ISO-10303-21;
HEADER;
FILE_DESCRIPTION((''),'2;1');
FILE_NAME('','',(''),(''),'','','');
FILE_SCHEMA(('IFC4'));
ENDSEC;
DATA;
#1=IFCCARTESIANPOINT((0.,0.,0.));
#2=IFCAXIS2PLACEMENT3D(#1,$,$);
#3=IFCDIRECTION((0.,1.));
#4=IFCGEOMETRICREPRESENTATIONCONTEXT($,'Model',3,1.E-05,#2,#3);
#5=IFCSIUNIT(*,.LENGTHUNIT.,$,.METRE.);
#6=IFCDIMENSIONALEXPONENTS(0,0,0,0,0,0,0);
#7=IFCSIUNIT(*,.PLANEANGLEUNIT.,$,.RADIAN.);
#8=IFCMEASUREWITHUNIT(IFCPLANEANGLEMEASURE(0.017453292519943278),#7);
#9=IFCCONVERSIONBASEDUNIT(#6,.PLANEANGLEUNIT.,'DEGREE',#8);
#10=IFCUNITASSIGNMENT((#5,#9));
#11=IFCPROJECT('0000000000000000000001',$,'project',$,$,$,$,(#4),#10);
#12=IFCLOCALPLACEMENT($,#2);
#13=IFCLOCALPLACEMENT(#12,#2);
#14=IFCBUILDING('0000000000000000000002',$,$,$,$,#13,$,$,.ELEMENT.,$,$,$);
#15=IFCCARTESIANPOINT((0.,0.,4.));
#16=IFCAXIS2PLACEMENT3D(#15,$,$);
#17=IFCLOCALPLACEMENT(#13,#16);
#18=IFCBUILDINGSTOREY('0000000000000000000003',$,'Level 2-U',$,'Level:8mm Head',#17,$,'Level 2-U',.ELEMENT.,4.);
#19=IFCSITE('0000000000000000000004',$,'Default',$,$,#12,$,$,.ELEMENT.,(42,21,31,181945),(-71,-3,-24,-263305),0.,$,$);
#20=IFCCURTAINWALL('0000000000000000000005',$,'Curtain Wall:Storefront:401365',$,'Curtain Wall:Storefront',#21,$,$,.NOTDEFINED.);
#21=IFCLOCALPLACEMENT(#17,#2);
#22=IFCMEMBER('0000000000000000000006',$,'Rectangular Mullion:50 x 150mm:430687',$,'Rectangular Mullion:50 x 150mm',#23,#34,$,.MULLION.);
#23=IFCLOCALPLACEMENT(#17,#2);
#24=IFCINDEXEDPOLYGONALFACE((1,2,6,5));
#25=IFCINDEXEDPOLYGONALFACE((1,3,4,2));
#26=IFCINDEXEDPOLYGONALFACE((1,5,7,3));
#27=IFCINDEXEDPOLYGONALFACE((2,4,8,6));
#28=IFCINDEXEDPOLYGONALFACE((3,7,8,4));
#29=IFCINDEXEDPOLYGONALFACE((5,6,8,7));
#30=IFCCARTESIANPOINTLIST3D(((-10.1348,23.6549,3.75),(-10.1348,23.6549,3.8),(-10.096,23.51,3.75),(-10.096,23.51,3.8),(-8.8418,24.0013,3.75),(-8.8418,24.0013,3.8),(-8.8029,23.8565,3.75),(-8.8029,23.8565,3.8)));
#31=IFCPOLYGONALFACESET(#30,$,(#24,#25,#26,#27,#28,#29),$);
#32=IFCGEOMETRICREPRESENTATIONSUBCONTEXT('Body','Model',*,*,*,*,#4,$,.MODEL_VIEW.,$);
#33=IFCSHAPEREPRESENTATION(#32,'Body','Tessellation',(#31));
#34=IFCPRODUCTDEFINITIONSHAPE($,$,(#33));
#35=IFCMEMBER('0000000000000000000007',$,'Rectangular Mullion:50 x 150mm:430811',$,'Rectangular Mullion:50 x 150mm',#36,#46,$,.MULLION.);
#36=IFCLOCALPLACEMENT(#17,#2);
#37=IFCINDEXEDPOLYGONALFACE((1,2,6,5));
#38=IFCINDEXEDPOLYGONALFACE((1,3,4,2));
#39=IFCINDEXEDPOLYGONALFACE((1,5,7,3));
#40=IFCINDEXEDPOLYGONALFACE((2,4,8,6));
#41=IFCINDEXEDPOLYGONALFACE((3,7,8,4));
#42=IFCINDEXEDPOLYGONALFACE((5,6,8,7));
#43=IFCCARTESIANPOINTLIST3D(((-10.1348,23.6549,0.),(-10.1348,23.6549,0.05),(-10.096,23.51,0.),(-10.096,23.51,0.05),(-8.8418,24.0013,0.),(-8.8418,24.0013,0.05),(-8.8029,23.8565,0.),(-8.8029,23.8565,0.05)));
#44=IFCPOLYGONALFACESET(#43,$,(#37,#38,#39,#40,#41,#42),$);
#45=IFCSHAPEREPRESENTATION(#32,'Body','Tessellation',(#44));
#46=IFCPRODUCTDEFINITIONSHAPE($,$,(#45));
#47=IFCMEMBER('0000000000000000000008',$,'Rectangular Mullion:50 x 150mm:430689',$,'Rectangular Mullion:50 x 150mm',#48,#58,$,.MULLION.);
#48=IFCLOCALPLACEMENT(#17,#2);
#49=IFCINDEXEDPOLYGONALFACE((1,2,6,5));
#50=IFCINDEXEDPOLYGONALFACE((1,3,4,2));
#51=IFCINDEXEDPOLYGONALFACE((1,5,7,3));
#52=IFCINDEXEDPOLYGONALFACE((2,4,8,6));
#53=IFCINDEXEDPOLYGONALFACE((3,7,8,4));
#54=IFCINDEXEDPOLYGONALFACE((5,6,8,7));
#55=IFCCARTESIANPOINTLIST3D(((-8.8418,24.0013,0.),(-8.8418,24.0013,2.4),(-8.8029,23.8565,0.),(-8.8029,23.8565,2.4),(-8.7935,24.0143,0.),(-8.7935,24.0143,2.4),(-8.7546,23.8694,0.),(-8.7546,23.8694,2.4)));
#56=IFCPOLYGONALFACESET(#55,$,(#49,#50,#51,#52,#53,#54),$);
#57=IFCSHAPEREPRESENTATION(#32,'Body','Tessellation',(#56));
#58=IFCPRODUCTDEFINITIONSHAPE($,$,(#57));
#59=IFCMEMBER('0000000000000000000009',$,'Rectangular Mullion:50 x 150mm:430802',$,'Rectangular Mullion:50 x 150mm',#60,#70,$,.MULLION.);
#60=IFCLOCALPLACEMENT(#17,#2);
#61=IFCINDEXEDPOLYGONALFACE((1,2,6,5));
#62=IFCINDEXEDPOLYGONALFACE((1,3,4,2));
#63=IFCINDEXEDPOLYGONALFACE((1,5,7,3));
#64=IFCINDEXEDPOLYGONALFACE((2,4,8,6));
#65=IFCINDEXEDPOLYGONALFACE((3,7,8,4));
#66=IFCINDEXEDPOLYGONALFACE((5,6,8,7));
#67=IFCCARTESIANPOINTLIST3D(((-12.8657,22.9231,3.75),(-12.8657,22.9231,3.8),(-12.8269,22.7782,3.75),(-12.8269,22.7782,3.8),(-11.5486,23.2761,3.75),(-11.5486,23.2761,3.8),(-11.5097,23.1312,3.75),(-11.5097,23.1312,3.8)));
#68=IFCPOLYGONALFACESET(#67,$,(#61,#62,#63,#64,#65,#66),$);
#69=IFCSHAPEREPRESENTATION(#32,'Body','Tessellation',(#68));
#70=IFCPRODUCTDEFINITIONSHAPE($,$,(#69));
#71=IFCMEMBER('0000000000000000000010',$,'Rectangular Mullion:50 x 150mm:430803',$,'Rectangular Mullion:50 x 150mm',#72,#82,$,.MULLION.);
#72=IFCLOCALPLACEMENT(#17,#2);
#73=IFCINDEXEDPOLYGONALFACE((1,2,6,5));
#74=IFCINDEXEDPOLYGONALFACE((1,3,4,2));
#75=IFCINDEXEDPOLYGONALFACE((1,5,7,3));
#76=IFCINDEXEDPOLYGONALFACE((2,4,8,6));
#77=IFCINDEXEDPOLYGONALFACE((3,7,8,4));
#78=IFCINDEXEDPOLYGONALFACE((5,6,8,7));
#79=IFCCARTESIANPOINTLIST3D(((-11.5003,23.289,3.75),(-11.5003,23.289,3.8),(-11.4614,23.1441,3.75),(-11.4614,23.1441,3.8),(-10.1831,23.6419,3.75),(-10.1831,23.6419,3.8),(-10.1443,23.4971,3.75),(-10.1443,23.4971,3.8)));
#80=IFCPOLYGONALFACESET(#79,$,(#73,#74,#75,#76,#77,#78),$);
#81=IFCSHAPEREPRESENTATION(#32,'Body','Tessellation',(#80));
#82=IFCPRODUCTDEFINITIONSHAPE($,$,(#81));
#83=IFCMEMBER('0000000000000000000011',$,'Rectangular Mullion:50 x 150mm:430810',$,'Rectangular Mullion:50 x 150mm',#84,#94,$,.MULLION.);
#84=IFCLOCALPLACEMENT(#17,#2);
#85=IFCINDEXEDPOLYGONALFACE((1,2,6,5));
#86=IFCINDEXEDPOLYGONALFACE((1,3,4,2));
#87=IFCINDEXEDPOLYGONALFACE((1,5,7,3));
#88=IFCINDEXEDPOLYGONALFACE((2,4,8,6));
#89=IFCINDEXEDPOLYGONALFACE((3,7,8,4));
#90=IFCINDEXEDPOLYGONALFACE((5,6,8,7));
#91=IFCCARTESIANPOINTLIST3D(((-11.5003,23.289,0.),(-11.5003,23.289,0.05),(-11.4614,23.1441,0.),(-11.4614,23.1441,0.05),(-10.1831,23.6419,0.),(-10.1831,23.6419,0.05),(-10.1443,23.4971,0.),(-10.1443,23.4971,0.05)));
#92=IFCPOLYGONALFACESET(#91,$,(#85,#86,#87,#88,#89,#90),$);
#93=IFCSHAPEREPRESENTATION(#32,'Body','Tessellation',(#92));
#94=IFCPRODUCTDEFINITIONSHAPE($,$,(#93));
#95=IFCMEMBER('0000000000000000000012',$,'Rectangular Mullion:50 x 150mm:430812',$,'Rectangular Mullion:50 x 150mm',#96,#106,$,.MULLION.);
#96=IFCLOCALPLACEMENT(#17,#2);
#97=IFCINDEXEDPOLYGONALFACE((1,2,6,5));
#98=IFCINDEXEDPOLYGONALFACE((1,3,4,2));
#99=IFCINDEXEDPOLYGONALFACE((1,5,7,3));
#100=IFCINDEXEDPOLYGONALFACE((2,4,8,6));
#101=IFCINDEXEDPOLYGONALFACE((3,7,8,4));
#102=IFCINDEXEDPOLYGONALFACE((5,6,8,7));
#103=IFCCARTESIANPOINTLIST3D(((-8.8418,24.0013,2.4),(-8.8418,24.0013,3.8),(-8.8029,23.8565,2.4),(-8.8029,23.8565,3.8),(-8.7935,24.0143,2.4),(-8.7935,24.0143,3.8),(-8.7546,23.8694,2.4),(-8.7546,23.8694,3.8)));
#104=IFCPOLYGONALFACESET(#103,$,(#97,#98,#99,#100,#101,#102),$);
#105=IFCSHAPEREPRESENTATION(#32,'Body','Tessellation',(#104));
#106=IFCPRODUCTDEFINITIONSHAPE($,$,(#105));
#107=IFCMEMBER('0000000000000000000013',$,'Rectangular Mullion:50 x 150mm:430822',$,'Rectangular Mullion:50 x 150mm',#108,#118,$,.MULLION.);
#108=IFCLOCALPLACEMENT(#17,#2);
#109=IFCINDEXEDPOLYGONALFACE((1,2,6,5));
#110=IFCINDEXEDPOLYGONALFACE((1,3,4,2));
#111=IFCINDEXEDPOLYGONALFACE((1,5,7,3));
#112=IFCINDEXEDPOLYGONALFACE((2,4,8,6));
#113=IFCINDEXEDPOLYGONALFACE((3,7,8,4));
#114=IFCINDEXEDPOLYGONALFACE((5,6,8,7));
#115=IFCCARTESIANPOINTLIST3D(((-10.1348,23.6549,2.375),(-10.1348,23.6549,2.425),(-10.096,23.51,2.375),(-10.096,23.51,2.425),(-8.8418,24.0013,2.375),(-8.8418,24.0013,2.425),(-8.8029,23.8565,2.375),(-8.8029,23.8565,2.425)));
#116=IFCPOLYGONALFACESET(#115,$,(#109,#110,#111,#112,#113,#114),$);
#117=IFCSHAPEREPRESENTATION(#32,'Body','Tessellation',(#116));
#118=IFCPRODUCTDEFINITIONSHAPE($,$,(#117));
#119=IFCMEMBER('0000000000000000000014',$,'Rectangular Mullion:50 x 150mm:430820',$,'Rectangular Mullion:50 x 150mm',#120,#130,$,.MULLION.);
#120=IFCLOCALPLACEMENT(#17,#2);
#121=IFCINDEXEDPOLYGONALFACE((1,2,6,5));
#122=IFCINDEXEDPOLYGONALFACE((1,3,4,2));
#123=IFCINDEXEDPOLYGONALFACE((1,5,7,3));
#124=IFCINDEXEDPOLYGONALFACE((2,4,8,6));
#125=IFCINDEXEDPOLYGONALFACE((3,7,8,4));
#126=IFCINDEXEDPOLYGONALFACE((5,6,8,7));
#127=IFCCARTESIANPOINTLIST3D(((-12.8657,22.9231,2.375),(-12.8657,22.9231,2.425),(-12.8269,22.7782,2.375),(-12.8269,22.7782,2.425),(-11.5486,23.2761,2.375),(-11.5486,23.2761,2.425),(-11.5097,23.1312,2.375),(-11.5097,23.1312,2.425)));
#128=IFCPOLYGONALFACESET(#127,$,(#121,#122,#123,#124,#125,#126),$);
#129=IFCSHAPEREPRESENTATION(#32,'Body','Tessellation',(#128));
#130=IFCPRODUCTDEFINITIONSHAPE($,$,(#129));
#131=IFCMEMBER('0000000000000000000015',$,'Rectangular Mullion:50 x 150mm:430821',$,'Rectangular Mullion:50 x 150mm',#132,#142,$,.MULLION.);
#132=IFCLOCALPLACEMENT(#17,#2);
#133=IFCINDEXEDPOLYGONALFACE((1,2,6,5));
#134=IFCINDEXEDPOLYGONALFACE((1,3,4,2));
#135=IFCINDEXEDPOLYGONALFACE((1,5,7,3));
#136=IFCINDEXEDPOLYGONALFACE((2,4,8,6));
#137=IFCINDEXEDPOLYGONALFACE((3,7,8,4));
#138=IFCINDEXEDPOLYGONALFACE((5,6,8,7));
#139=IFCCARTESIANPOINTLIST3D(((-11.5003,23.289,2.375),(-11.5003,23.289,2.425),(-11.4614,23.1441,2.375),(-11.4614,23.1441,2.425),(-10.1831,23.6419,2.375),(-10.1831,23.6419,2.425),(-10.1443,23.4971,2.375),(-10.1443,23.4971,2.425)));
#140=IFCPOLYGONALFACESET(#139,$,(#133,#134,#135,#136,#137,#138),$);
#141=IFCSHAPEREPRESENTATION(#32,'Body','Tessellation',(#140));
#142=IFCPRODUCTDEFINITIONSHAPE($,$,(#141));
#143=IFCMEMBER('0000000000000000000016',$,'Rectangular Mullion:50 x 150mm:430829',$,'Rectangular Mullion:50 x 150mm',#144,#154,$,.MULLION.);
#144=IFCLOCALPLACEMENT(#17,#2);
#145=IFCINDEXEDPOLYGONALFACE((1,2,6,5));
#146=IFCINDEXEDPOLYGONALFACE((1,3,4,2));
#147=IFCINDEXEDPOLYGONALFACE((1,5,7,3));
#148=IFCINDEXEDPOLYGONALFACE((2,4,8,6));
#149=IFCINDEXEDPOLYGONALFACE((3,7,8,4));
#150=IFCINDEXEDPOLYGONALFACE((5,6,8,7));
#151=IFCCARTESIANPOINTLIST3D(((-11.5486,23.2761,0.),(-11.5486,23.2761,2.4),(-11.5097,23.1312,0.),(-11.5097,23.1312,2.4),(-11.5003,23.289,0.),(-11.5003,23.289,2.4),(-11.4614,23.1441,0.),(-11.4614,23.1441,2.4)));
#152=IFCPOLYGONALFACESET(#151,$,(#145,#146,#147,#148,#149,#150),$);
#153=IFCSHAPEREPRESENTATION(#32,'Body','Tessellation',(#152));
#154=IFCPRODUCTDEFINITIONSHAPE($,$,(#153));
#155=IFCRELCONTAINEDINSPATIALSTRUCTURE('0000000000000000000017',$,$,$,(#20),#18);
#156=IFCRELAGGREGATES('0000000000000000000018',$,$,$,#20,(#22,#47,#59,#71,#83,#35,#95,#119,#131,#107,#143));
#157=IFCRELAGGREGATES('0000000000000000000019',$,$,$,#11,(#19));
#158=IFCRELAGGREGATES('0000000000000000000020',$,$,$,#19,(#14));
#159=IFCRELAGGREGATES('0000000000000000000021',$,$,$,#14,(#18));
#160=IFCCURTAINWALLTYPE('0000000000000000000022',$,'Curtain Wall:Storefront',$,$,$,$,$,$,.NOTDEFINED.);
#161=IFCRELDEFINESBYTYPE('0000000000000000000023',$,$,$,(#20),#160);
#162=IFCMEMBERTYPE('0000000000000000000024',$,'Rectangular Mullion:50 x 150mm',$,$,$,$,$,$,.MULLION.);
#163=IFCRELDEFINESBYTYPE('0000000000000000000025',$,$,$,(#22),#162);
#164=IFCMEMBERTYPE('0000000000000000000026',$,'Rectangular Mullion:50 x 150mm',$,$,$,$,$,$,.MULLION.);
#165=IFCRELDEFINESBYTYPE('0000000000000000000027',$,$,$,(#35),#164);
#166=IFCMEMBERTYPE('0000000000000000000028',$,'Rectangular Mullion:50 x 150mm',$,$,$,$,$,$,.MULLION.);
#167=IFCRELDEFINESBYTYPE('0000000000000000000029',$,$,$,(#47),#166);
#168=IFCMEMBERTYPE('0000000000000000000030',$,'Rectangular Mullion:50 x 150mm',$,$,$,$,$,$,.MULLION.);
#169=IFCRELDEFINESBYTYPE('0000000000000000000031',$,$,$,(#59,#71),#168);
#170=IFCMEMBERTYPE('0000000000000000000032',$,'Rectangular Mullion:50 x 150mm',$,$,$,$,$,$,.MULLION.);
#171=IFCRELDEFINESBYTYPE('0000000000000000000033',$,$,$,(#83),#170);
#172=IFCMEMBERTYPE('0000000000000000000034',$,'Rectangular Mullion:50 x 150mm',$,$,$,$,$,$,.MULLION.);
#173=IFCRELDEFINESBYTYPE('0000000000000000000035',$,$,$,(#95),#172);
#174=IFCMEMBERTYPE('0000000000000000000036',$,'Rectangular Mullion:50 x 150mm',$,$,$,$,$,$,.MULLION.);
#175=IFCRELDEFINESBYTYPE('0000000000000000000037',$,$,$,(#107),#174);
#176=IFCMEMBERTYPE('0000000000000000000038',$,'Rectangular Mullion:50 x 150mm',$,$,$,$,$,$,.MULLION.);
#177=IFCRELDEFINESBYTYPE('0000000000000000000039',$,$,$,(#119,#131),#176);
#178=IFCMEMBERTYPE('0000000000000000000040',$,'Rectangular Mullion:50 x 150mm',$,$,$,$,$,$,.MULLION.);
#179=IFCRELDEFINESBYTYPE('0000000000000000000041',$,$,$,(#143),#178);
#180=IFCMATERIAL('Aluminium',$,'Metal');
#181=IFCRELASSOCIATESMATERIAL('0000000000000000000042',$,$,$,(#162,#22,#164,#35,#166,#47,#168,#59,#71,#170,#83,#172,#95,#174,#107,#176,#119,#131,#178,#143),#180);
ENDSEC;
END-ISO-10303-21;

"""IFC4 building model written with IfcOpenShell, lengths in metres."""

from ifc_helpers import new_model, entity, si_unit, converted_unit, direction, frame, origin, place, context, subcontext, project, spatial, indexed_curve, outline, extrude, source, transform, mapped, material, type_object, type_shapes, element, aggregate, save


model = new_model("IFC4")

# Units and contexts
model_context = context("Model", 3, precision=1e-05, world=origin(), true_north=direction((0.0, 1.0)))
body_context = subcontext(model_context, "Body", "Model", "MODEL_VIEW")
ifc_project = project(units=[si_unit("LENGTHUNIT", "METRE"), converted_unit("PLANEANGLEUNIT", "DEGREE", entity("IfcPlaneAngleMeasure", 0.017453292519943278), si_unit("PLANEANGLEUNIT", "RADIAN"), dimensions=[0, 0, 0, 0, 0, 0, 0])], contexts=[model_context])

# Site, building, storey
site_placement = place(None, origin())
site = spatial("IfcSite", under=ifc_project, at=site_placement, Name="Default", CompositionType="ELEMENT", RefLatitude=(42, 21, 31, 181945), RefLongitude=(-71, -3, -24, -263305), RefElevation=0.0)
building_placement = place(site_placement, origin())
building = spatial("IfcBuilding", under=site, at=building_placement, CompositionType="ELEMENT")
storey_placement = place(building_placement, frame((0.0, 0.0, 4.0)))
storey = spatial("IfcBuildingStorey", under=building, at=storey_placement, Name="Level 2-U", ObjectType="Level:8mm Head", LongName="Level 2-U", CompositionType="ELEMENT", Elevation=4.0)

# Curtain wall, members
curtain_wall_type = type_object("IfcCurtainWallType", Name="Curtain Wall:Storefront", PredefinedType="NOTDEFINED")
curtain_wall_placement = place(storey_placement, frame((0.0, 0.0, -4.0)))
curtain_wall = element("IfcCurtainWall", 1, at=curtain_wall_placement, inside=storey, type_object=curtain_wall_type, Name="Curtain Wall:Storefront:401365", ObjectType="Curtain Wall:Storefront", PredefinedType="NOTDEFINED")
ifc_material_1 = material(Name="Aluminium", Category="Metal")
member_type_1 = type_object("IfcMemberType", Name="Rectangular Mullion:50 x 150mm", PredefinedType="MULLION", material=ifc_material_1)
shared_shape_1 = source(origin(), body_context, "Body", "SweptSolid", [
    extrude(outline(indexed_curve([(-0.025, -0.075), (0.025, -0.075), (0.025, 0.075), (-0.025, 0.075), (-0.025, -0.075)], self_intersect=False)), frame((-0.025, 0.0, -1.3386), z_axis=(0.0, 0.0, 1.0), x_axis=(-1.0, 0.0, 0.0)), (0.0, 0.0, 1.0), 1.3386),
])
type_shapes(member_type_1, [shared_shape_1])
member_1_placement = place(curtain_wall_placement, frame((-8.8224, 23.9289, 7.8), z_axis=(0.965926, 0.258819, 0.0), x_axis=(0.0, 0.0, 1.0)))
member_1 = element("IfcMember", 2, at=member_1_placement, type_object=member_type_1, material=ifc_material_1, Name="Rectangular Mullion:50 x 150mm:430687", ObjectType="Rectangular Mullion:50 x 150mm", PredefinedType="MULLION", context=body_context, shape_type="MappedRepresentation", body=[
    mapped(shared_shape_1, transform((0.0, 0.0, 0.0), scale=1.0)),
])
member_type_2 = type_object("IfcMemberType", Name="Rectangular Mullion:50 x 150mm", PredefinedType="MULLION", material=ifc_material_1)
shared_shape_2 = source(origin(), body_context, "Body", "SweptSolid", [
    extrude(outline(indexed_curve([(-0.025, -0.075), (0.025, -0.075), (0.025, 0.075), (-0.025, 0.075), (-0.025, -0.075)], self_intersect=False)), frame((-0.025, 0.0, -1.3386), z_axis=(0.0, 0.0, 1.0), x_axis=(-1.0, 0.0, 0.0)), (0.0, 0.0, 1.0), 1.3386),
])
type_shapes(member_type_2, [shared_shape_2])
member_2_placement = place(curtain_wall_placement, frame((-10.1154, 23.5824, 4.0), z_axis=(-0.965926, -0.258819, 0.0), x_axis=(0.0, 0.0, -1.0)))
member_2 = element("IfcMember", 3, at=member_2_placement, type_object=member_type_2, material=ifc_material_1, Name="Rectangular Mullion:50 x 150mm:430811", ObjectType="Rectangular Mullion:50 x 150mm", PredefinedType="MULLION", context=body_context, shape_type="MappedRepresentation", body=[
    mapped(shared_shape_2, transform((0.0, 0.0, 0.0), scale=1.0)),
])
member_type_3 = type_object("IfcMemberType", Name="Rectangular Mullion:50 x 150mm", PredefinedType="MULLION", material=ifc_material_1)
shared_shape_3 = source(origin(), body_context, "Body", "SweptSolid", [
    extrude(outline(indexed_curve([(-0.025, -0.075), (0.025, -0.075), (0.025, 0.075), (-0.025, 0.075), (-0.025, -0.075)], self_intersect=False)), frame((-0.025, 0.0, -2.4), z_axis=(0.0, 0.0, 1.0), x_axis=(-1.0, 0.0, 0.0)), (0.0, 0.0, 1.0), 2.4),
])
type_shapes(member_type_3, [shared_shape_3])
member_3_placement = place(curtain_wall_placement, frame((-8.7741, 23.9418, 4.0), z_axis=(0.0, 0.0, -1.0), x_axis=(0.965926, 0.258819, 0.0)))
member_3 = element("IfcMember", 4, at=member_3_placement, type_object=member_type_3, material=ifc_material_1, Name="Rectangular Mullion:50 x 150mm:430689", ObjectType="Rectangular Mullion:50 x 150mm", PredefinedType="MULLION", context=body_context, shape_type="MappedRepresentation", body=[
    mapped(shared_shape_3, transform((0.0, 0.0, 0.0), scale=1.0)),
])
member_type_4 = type_object("IfcMemberType", Name="Rectangular Mullion:50 x 150mm", PredefinedType="MULLION", material=ifc_material_1)
shared_shape_4 = source(origin(), body_context, "Body", "SweptSolid", [
    extrude(outline(indexed_curve([(-0.025, -0.075), (0.025, -0.075), (0.025, 0.075), (-0.025, 0.075), (-0.025, -0.075)], self_intersect=False)), frame((-0.025, 0.0, -1.3636), z_axis=(0.0, 0.0, 1.0), x_axis=(-1.0, 0.0, 0.0)), (0.0, 0.0, 1.0), 1.3636),
])
type_shapes(member_type_4, [shared_shape_4])
member_4_placement = place(curtain_wall_placement, frame((-11.5291, 23.2036, 7.8), z_axis=(0.965926, 0.258819, 0.0), x_axis=(0.0, 0.0, 1.0)))
member_4 = element("IfcMember", 5, at=member_4_placement, type_object=member_type_4, material=ifc_material_1, Name="Rectangular Mullion:50 x 150mm:430802", ObjectType="Rectangular Mullion:50 x 150mm", PredefinedType="MULLION", context=body_context, shape_type="MappedRepresentation", body=[
    mapped(shared_shape_4, transform((0.0, 0.0, 0.0), scale=1.0)),
])
member_5_placement = place(curtain_wall_placement, frame((-10.1637, 23.5695, 7.8), z_axis=(0.965926, 0.258819, 0.0), x_axis=(0.0, 0.0, 1.0)))
member_5 = element("IfcMember", 6, at=member_5_placement, type_object=member_type_4, material=ifc_material_1, Name="Rectangular Mullion:50 x 150mm:430803", ObjectType="Rectangular Mullion:50 x 150mm", PredefinedType="MULLION", context=body_context, shape_type="MappedRepresentation", body=[
    mapped(shared_shape_4, transform((0.0, 0.0, 0.0), scale=1.0)),
])
member_type_5 = type_object("IfcMemberType", Name="Rectangular Mullion:50 x 150mm", PredefinedType="MULLION", material=ifc_material_1)
shared_shape_5 = source(origin(), body_context, "Body", "SweptSolid", [
    extrude(outline(indexed_curve([(-0.025, -0.075), (0.025, -0.075), (0.025, 0.075), (-0.025, 0.075), (-0.025, -0.075)], self_intersect=False)), frame((-0.025, 0.0, -1.3636), z_axis=(0.0, 0.0, 1.0), x_axis=(-1.0, 0.0, 0.0)), (0.0, 0.0, 1.0), 1.3636),
])
type_shapes(member_type_5, [shared_shape_5])
member_6_placement = place(curtain_wall_placement, frame((-11.4809, 23.2166, 4.0), z_axis=(-0.965926, -0.258819, 0.0), x_axis=(0.0, 0.0, -1.0)))
member_6 = element("IfcMember", 7, at=member_6_placement, type_object=member_type_5, material=ifc_material_1, Name="Rectangular Mullion:50 x 150mm:430810", ObjectType="Rectangular Mullion:50 x 150mm", PredefinedType="MULLION", context=body_context, shape_type="MappedRepresentation", body=[
    mapped(shared_shape_5, transform((0.0, 0.0, 0.0), scale=1.0)),
])
member_type_6 = type_object("IfcMemberType", Name="Rectangular Mullion:50 x 150mm", PredefinedType="MULLION", material=ifc_material_1)
shared_shape_6 = source(origin(), body_context, "Body", "SweptSolid", [
    extrude(outline(indexed_curve([(-0.025, -0.075), (0.025, -0.075), (0.025, 0.075), (-0.025, 0.075), (-0.025, -0.075)], self_intersect=False)), frame((-0.025, 0.0, -1.4), z_axis=(0.0, 0.0, 1.0), x_axis=(-1.0, 0.0, 0.0)), (0.0, 0.0, 1.0), 1.4),
])
type_shapes(member_type_6, [shared_shape_6])
member_7_placement = place(curtain_wall_placement, frame((-8.7741, 23.9418, 6.4), z_axis=(0.0, 0.0, -1.0), x_axis=(0.965926, 0.258819, 0.0)))
member_7 = element("IfcMember", 8, at=member_7_placement, type_object=member_type_6, material=ifc_material_1, Name="Rectangular Mullion:50 x 150mm:430812", ObjectType="Rectangular Mullion:50 x 150mm", PredefinedType="MULLION", context=body_context, shape_type="MappedRepresentation", body=[
    mapped(shared_shape_6, transform((0.0, 0.0, 0.0), scale=1.0)),
])
member_type_7 = type_object("IfcMemberType", Name="Rectangular Mullion:50 x 150mm", PredefinedType="MULLION", material=ifc_material_1)
shared_shape_7 = source(origin(), body_context, "Body", "SweptSolid", [
    extrude(outline(indexed_curve([(-0.025, -0.075), (0.025, -0.075), (0.025, 0.075), (-0.025, 0.075), (-0.025, -0.075)], self_intersect=False)), frame((0.0, 0.0, -1.3386), z_axis=(0.0, 0.0, 1.0), x_axis=(-1.0, 0.0, 0.0)), (0.0, 0.0, 1.0), 1.3386),
])
type_shapes(member_type_7, [shared_shape_7])
member_8_placement = place(curtain_wall_placement, frame((-8.8224, 23.9289, 6.4), z_axis=(0.965926, 0.258819, 0.0), x_axis=(0.0, 0.0, 1.0)))
member_8 = element("IfcMember", 9, at=member_8_placement, type_object=member_type_7, material=ifc_material_1, Name="Rectangular Mullion:50 x 150mm:430822", ObjectType="Rectangular Mullion:50 x 150mm", PredefinedType="MULLION", context=body_context, shape_type="MappedRepresentation", body=[
    mapped(shared_shape_7, transform((0.0, 0.0, 0.0), scale=1.0)),
])
member_type_8 = type_object("IfcMemberType", Name="Rectangular Mullion:50 x 150mm", PredefinedType="MULLION", material=ifc_material_1)
shared_shape_8 = source(origin(), body_context, "Body", "SweptSolid", [
    extrude(outline(indexed_curve([(-0.025, -0.075), (0.025, -0.075), (0.025, 0.075), (-0.025, 0.075), (-0.025, -0.075)], self_intersect=False)), frame((0.0, 0.0, -1.3636), z_axis=(0.0, 0.0, 1.0), x_axis=(-1.0, 0.0, 0.0)), (0.0, 0.0, 1.0), 1.3636),
])
type_shapes(member_type_8, [shared_shape_8])
member_9_placement = place(curtain_wall_placement, frame((-11.5291, 23.2036, 6.4), z_axis=(0.965926, 0.258819, 0.0), x_axis=(0.0, 0.0, 1.0)))
member_9 = element("IfcMember", 10, at=member_9_placement, type_object=member_type_8, material=ifc_material_1, Name="Rectangular Mullion:50 x 150mm:430820", ObjectType="Rectangular Mullion:50 x 150mm", PredefinedType="MULLION", context=body_context, shape_type="MappedRepresentation", body=[
    mapped(shared_shape_8, transform((0.0, 0.0, 0.0), scale=1.0)),
])
member_10_placement = place(curtain_wall_placement, frame((-10.1637, 23.5695, 6.4), z_axis=(0.965926, 0.258819, 0.0), x_axis=(0.0, 0.0, 1.0)))
member_10 = element("IfcMember", 11, at=member_10_placement, type_object=member_type_8, material=ifc_material_1, Name="Rectangular Mullion:50 x 150mm:430821", ObjectType="Rectangular Mullion:50 x 150mm", PredefinedType="MULLION", context=body_context, shape_type="MappedRepresentation", body=[
    mapped(shared_shape_8, transform((0.0, 0.0, 0.0), scale=1.0)),
])
member_type_9 = type_object("IfcMemberType", Name="Rectangular Mullion:50 x 150mm", PredefinedType="MULLION", material=ifc_material_1)
shared_shape_9 = source(origin(), body_context, "Body", "SweptSolid", [
    extrude(outline(indexed_curve([(-0.025, -0.075), (0.025, -0.075), (0.025, 0.075), (-0.025, 0.075), (-0.025, -0.075)], self_intersect=False)), frame((0.0, 0.0, -2.4), z_axis=(0.0, 0.0, 1.0), x_axis=(-1.0, 0.0, 0.0)), (0.0, 0.0, 1.0), 2.4),
])
type_shapes(member_type_9, [shared_shape_9])
member_11_placement = place(curtain_wall_placement, frame((-11.505, 23.2101, 4.0), z_axis=(0.0, 0.0, -1.0), x_axis=(0.965926, 0.258819, 0.0)))
member_11 = element("IfcMember", 12, at=member_11_placement, type_object=member_type_9, material=ifc_material_1, Name="Rectangular Mullion:50 x 150mm:430829", ObjectType="Rectangular Mullion:50 x 150mm", PredefinedType="MULLION", context=body_context, shape_type="MappedRepresentation", body=[
    mapped(shared_shape_9, transform((0.0, 0.0, 0.0), scale=1.0)),
])
aggregate(curtain_wall, [member_1, member_3, member_4, member_5, member_6, member_2, member_7, member_9, member_10, member_8, member_11])

save(model, "model.ifc")
